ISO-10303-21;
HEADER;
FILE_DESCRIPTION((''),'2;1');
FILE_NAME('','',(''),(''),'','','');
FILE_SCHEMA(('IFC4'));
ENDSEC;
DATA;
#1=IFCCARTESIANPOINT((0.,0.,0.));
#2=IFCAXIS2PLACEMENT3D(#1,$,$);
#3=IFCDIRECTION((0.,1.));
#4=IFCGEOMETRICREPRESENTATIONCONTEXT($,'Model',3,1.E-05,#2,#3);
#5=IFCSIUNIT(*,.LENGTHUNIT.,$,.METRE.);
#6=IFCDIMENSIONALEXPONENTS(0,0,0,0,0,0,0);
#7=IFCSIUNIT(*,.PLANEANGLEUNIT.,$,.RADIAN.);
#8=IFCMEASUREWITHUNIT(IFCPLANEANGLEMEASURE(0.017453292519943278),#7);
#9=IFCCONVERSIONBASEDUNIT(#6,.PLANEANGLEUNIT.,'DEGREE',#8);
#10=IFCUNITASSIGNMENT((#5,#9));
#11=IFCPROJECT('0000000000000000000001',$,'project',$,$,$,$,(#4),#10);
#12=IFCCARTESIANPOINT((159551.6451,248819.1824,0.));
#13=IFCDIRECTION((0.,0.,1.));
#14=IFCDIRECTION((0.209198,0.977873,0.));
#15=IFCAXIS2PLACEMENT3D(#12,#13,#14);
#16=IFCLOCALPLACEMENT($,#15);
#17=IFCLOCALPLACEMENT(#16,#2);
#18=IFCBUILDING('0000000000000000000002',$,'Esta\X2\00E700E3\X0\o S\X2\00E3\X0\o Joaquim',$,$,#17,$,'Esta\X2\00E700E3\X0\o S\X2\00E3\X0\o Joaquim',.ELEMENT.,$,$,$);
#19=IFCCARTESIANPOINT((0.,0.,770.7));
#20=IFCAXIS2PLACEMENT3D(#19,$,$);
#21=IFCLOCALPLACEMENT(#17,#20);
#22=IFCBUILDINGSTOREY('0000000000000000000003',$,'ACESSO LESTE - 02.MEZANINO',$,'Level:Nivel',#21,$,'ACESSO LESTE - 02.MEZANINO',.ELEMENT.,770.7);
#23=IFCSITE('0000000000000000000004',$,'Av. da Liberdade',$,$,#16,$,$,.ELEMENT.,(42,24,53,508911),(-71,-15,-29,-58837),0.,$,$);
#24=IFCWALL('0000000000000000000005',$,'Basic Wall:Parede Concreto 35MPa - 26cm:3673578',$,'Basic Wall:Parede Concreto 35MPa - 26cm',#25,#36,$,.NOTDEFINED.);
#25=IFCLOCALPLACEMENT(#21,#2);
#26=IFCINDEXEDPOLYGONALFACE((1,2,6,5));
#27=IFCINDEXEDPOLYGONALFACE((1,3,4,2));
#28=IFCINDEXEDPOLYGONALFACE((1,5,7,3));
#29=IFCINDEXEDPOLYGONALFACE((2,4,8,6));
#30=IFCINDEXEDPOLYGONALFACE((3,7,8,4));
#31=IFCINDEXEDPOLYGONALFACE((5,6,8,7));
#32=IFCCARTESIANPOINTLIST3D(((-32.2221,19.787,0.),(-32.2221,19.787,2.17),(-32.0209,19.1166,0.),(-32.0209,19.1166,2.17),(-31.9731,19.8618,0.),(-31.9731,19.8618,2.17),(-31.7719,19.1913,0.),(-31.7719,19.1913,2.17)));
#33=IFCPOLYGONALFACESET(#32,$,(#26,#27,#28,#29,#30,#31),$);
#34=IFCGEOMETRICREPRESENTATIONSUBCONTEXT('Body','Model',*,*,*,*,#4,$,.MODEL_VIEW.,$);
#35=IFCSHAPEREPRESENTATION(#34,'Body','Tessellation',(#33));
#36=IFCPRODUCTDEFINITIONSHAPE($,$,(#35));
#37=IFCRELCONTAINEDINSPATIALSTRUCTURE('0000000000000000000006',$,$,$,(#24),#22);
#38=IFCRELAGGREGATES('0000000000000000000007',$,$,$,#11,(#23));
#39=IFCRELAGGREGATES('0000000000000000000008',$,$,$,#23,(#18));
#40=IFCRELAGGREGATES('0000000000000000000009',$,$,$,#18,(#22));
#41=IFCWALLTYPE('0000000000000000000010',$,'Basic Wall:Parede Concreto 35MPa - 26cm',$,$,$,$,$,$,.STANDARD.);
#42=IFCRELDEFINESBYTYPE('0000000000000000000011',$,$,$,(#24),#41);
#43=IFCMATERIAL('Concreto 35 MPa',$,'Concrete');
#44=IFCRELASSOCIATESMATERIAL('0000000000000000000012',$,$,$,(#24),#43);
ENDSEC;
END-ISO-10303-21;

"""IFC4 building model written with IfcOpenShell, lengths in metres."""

from ifc_helpers import new_model, entity, si_unit, converted_unit, direction, frame, origin, place, context, subcontext, project, spatial, indexed_curve, outline, extrude, material, type_object, element, save


model = new_model("IFC4")

# Units and contexts
model_context = context("Model", 3, precision=1e-05, world=origin(), true_north=direction((0.0, 1.0)))
body_context = subcontext(model_context, "Body", "Model", "MODEL_VIEW")
ifc_project = project(units=[si_unit("LENGTHUNIT", "METRE"), converted_unit("PLANEANGLEUNIT", "DEGREE", entity("IfcPlaneAngleMeasure", 0.017453292519943278), si_unit("PLANEANGLEUNIT", "RADIAN"), dimensions=[0, 0, 0, 0, 0, 0, 0])], contexts=[model_context])

# Site, building, storey
site_placement = place(None, frame((159551.6451, 248819.1824, 0.0), z_axis=(0.0, 0.0, 1.0), x_axis=(0.209198, 0.977873, 0.0)))
site = spatial("IfcSite", under=ifc_project, at=site_placement, Name="Av. da Liberdade", CompositionType="ELEMENT", RefLatitude=(42, 24, 53, 508911), RefLongitude=(-71, -15, -29, -58837), RefElevation=0.0)
building_placement = place(site_placement, origin())
building = spatial("IfcBuilding", under=site, at=building_placement, Name="Estação São Joaquim", LongName="Estação São Joaquim", CompositionType="ELEMENT")
storey_placement = place(building_placement, frame((0.0, 0.0, 770.7)))
storey = spatial("IfcBuildingStorey", under=building, at=storey_placement, Name="ACESSO LESTE - 02.MEZANINO", ObjectType="Level:Nivel", LongName="ACESSO LESTE - 02.MEZANINO", CompositionType="ELEMENT", Elevation=770.7)

# Shared definitions
ifc_material = material(Name="Concreto 35 MPa", Category="Concrete")

# Wall
wall_type_1 = type_object("IfcWallType", Name="Basic Wall:Parede Concreto 35MPa - 26cm", PredefinedType="STANDARD")
wall_1_placement = place(storey_placement, frame((-31.8964, 19.1539, 0.0), z_axis=(0.0, 0.0, 1.0), x_axis=(-0.287441, 0.957798, 0.0)))
element("IfcWall", 1, at=wall_1_placement, inside=storey, type_object=wall_type_1, material=ifc_material, Name="Basic Wall:Parede Concreto 35MPa - 26cm:3673578", ObjectType="Basic Wall:Parede Concreto 35MPa - 26cm", PredefinedType="NOTDEFINED", context=body_context, shape_type="SweptSolid", body=[
    extrude(outline(indexed_curve([(0.7, 0.13), (0.0, 0.13), (0.0, -0.13), (0.7, -0.13), (0.7, 0.13)], self_intersect=False)), origin(), (0.0, 0.0, 1.0), 2.17),
])

save(model, "model.ifc")
